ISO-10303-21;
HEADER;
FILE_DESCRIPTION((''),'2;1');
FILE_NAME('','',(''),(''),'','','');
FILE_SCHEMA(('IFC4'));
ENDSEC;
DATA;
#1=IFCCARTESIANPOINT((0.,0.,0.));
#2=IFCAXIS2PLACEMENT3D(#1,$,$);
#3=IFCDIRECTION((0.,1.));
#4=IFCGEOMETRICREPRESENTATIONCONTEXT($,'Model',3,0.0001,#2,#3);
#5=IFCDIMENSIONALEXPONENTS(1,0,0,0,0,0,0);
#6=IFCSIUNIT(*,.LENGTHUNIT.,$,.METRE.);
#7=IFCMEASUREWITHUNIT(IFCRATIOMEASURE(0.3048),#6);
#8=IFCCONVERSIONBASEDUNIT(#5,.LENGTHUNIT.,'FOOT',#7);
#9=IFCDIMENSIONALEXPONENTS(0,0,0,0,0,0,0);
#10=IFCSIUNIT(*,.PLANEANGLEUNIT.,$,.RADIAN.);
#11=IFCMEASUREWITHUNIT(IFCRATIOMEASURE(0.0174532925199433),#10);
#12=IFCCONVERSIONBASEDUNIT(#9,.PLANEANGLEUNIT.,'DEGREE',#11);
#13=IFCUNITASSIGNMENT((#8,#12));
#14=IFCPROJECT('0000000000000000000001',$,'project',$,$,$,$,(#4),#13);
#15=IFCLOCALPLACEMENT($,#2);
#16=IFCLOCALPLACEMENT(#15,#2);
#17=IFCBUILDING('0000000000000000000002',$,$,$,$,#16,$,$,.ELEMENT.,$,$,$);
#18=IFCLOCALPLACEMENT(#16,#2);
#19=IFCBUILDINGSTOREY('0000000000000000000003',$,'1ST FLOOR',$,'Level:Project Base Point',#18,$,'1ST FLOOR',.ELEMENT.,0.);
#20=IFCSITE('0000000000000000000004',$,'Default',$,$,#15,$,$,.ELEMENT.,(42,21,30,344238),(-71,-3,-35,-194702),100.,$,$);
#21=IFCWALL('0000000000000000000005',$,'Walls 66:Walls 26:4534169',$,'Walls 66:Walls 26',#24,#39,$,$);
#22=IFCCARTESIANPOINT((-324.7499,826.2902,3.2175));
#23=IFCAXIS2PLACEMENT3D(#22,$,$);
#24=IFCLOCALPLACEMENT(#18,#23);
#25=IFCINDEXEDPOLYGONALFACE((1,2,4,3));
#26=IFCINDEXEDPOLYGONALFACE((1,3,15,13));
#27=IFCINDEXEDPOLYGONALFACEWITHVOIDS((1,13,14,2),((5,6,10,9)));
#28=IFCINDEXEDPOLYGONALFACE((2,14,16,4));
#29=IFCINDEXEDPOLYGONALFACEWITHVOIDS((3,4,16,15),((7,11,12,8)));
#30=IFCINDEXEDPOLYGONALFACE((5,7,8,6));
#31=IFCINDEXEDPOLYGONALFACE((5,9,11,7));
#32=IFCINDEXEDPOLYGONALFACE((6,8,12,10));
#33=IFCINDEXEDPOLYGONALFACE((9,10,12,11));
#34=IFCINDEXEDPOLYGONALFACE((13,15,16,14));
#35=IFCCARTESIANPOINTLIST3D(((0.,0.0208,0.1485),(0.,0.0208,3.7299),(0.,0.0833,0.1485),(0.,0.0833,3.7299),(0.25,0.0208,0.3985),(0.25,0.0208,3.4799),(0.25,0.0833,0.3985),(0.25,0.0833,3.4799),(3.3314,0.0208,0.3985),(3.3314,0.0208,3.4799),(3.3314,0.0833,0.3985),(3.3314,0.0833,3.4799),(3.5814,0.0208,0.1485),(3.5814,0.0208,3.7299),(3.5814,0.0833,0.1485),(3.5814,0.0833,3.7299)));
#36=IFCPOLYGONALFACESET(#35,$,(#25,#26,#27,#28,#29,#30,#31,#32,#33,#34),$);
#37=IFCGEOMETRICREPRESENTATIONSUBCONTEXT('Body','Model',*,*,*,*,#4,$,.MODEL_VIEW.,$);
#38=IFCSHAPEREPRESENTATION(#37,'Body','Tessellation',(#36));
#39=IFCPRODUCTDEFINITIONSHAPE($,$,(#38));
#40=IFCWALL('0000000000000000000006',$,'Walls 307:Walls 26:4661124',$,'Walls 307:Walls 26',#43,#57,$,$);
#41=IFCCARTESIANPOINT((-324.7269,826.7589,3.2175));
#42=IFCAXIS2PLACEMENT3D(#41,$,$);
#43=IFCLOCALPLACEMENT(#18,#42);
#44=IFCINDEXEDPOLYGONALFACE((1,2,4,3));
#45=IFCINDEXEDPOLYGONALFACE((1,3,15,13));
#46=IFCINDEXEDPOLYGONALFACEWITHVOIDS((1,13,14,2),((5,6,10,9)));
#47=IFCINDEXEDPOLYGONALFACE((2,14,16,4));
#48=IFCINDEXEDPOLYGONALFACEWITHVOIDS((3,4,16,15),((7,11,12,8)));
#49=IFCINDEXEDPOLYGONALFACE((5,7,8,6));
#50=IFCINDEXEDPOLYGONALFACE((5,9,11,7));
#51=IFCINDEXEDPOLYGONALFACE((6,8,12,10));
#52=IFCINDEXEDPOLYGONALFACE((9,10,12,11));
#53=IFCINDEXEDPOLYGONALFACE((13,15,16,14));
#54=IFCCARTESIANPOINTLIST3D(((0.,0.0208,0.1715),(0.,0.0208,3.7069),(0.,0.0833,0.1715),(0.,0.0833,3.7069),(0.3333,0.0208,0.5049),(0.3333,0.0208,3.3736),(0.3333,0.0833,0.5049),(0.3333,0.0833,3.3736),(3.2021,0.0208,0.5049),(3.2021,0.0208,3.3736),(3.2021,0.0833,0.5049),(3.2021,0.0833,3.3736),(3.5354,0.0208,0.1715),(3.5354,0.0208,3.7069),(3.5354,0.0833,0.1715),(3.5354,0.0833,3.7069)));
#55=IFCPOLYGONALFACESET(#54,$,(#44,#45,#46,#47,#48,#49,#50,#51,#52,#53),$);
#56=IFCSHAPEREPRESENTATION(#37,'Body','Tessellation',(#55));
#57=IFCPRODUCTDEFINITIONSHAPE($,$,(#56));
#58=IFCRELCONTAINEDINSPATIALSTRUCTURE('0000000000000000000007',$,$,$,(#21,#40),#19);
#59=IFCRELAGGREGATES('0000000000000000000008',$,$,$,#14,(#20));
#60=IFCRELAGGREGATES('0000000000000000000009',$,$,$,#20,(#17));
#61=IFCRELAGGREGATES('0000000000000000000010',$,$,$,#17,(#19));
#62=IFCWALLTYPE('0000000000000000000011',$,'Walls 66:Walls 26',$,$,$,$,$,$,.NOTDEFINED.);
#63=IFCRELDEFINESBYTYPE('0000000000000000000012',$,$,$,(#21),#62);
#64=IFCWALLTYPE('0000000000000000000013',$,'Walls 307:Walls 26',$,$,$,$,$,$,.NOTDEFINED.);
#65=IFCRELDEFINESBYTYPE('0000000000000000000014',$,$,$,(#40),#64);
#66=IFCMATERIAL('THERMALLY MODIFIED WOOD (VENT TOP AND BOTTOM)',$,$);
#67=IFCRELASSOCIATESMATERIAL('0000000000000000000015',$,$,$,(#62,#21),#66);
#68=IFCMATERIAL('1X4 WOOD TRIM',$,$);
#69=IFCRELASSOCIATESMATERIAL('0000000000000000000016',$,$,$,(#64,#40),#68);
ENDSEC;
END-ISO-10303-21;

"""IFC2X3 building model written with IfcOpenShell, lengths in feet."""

from ifc_helpers import new_model, entity, si_unit, converted_unit, direction, frame, frame_2d, origin, place, context, subcontext, project, spatial, rectangle, extrude, material, type_object, element, save


model = new_model("IFC2X3")

# Units and contexts
model_context = context("Model", 3, precision=0.0001, world=origin(), true_north=direction((0.0, 1.0)))
body_context = subcontext(model_context, "Body", "Model", "MODEL_VIEW")
ifc_project = project(units=[converted_unit("LENGTHUNIT", "FOOT", entity("IfcRatioMeasure", 0.3048), si_unit("LENGTHUNIT", "METRE"), dimensions=[1, 0, 0, 0, 0, 0, 0]), converted_unit("PLANEANGLEUNIT", "DEGREE", entity("IfcRatioMeasure", 0.0174532925199433), si_unit("PLANEANGLEUNIT", "RADIAN"), dimensions=[0, 0, 0, 0, 0, 0, 0])], contexts=[model_context])

# Site, building, storey
site_placement = place(None, origin())
site = spatial("IfcSite", under=ifc_project, at=site_placement, Name="Default", CompositionType="ELEMENT", RefLatitude=(42, 21, 30, 344238), RefLongitude=(-71, -3, -35, -194702), RefElevation=100.0)
building_placement = place(site_placement, origin())
building = spatial("IfcBuilding", under=site, at=building_placement, CompositionType="ELEMENT")
storey_placement = place(building_placement, origin())
storey = spatial("IfcBuildingStorey", under=building, at=storey_placement, Name="1ST FLOOR", ObjectType="Level:Project Base Point", LongName="1ST FLOOR", CompositionType="ELEMENT", Elevation=0.0)

# Wall, opening
ifc_material_1 = material(Name="THERMALLY MODIFIED WOOD (VENT TOP AND BOTTOM)")
wall_type_1 = type_object("IfcWallType", Name="Walls 66:Walls 26", PredefinedType="NOTDEFINED", material=ifc_material_1)
wall_1_placement = place(storey_placement, frame((-324.7499, 826.2902, 3.2175)))
wall_1 = element("IfcWall", 1, at=wall_1_placement, inside=storey, type_object=wall_type_1, material=ifc_material_1, Name="Walls 66:Walls 26:4534169", ObjectType="Walls 66:Walls 26", context=body_context, shape_type="SweptSolid", body=[
    extrude(rectangle(XDim=3.5814, YDim=0.0625, at=frame_2d((0.0, 0.0), x_axis=(1.0, 0.0))), frame((1.7907, 0.052, 0.1485)), (0.0, 0.0, 1.0), 3.5814),
])
opening_1_placement = place(storey_placement, frame((-324.7499, 826.2902, 3.2175)))
element("IfcOpeningElement", 2, at=opening_1_placement, cuts=wall_1, ObjectType="Opening", context=body_context, shape_type="SweptSolid", body=[
    extrude(rectangle(XDim=3.0814, YDim=3.0814, at=frame_2d((0.0, 0.0), x_axis=(0.0, 1.0))), frame((1.7907, 0.0833, 1.9392), z_axis=(0.0, -1.0, 0.0), x_axis=(-1.0, 0.0, 0.0)), (0.0, 0.0, 1.0), 0.0625),
])

# Wall, opening
ifc_material_2 = material(Name="1X4 WOOD TRIM")
wall_type_2 = type_object("IfcWallType", Name="Walls 307:Walls 26", PredefinedType="NOTDEFINED", material=ifc_material_2)
wall_2_placement = place(storey_placement, frame((-324.7269, 826.7589, 3.2175)))
wall_2 = element("IfcWall", 3, at=wall_2_placement, inside=storey, type_object=wall_type_2, material=ifc_material_2, Name="Walls 307:Walls 26:4661124", ObjectType="Walls 307:Walls 26", context=body_context, shape_type="SweptSolid", body=[
    extrude(rectangle(XDim=3.5354, YDim=0.0625, at=frame_2d((0.0, 0.0), x_axis=(1.0, 0.0))), frame((1.7677, 0.052, 0.1715)), (0.0, 0.0, 1.0), 3.5354),
])
opening_2_placement = place(storey_placement, frame((-324.7269, 826.7589, 3.2175)))
element("IfcOpeningElement", 4, at=opening_2_placement, cuts=wall_2, ObjectType="Opening", context=body_context, shape_type="SweptSolid", body=[
    extrude(rectangle(XDim=2.8687, YDim=2.8687, at=frame_2d((0.0, 0.0), x_axis=(0.0, 1.0))), frame((1.7677, 0.0833, 1.9392), z_axis=(0.0, -1.0, 0.0), x_axis=(-1.0, 0.0, 0.0)), (0.0, 0.0, 1.0), 0.0625),
])

save(model, "model.ifc")
